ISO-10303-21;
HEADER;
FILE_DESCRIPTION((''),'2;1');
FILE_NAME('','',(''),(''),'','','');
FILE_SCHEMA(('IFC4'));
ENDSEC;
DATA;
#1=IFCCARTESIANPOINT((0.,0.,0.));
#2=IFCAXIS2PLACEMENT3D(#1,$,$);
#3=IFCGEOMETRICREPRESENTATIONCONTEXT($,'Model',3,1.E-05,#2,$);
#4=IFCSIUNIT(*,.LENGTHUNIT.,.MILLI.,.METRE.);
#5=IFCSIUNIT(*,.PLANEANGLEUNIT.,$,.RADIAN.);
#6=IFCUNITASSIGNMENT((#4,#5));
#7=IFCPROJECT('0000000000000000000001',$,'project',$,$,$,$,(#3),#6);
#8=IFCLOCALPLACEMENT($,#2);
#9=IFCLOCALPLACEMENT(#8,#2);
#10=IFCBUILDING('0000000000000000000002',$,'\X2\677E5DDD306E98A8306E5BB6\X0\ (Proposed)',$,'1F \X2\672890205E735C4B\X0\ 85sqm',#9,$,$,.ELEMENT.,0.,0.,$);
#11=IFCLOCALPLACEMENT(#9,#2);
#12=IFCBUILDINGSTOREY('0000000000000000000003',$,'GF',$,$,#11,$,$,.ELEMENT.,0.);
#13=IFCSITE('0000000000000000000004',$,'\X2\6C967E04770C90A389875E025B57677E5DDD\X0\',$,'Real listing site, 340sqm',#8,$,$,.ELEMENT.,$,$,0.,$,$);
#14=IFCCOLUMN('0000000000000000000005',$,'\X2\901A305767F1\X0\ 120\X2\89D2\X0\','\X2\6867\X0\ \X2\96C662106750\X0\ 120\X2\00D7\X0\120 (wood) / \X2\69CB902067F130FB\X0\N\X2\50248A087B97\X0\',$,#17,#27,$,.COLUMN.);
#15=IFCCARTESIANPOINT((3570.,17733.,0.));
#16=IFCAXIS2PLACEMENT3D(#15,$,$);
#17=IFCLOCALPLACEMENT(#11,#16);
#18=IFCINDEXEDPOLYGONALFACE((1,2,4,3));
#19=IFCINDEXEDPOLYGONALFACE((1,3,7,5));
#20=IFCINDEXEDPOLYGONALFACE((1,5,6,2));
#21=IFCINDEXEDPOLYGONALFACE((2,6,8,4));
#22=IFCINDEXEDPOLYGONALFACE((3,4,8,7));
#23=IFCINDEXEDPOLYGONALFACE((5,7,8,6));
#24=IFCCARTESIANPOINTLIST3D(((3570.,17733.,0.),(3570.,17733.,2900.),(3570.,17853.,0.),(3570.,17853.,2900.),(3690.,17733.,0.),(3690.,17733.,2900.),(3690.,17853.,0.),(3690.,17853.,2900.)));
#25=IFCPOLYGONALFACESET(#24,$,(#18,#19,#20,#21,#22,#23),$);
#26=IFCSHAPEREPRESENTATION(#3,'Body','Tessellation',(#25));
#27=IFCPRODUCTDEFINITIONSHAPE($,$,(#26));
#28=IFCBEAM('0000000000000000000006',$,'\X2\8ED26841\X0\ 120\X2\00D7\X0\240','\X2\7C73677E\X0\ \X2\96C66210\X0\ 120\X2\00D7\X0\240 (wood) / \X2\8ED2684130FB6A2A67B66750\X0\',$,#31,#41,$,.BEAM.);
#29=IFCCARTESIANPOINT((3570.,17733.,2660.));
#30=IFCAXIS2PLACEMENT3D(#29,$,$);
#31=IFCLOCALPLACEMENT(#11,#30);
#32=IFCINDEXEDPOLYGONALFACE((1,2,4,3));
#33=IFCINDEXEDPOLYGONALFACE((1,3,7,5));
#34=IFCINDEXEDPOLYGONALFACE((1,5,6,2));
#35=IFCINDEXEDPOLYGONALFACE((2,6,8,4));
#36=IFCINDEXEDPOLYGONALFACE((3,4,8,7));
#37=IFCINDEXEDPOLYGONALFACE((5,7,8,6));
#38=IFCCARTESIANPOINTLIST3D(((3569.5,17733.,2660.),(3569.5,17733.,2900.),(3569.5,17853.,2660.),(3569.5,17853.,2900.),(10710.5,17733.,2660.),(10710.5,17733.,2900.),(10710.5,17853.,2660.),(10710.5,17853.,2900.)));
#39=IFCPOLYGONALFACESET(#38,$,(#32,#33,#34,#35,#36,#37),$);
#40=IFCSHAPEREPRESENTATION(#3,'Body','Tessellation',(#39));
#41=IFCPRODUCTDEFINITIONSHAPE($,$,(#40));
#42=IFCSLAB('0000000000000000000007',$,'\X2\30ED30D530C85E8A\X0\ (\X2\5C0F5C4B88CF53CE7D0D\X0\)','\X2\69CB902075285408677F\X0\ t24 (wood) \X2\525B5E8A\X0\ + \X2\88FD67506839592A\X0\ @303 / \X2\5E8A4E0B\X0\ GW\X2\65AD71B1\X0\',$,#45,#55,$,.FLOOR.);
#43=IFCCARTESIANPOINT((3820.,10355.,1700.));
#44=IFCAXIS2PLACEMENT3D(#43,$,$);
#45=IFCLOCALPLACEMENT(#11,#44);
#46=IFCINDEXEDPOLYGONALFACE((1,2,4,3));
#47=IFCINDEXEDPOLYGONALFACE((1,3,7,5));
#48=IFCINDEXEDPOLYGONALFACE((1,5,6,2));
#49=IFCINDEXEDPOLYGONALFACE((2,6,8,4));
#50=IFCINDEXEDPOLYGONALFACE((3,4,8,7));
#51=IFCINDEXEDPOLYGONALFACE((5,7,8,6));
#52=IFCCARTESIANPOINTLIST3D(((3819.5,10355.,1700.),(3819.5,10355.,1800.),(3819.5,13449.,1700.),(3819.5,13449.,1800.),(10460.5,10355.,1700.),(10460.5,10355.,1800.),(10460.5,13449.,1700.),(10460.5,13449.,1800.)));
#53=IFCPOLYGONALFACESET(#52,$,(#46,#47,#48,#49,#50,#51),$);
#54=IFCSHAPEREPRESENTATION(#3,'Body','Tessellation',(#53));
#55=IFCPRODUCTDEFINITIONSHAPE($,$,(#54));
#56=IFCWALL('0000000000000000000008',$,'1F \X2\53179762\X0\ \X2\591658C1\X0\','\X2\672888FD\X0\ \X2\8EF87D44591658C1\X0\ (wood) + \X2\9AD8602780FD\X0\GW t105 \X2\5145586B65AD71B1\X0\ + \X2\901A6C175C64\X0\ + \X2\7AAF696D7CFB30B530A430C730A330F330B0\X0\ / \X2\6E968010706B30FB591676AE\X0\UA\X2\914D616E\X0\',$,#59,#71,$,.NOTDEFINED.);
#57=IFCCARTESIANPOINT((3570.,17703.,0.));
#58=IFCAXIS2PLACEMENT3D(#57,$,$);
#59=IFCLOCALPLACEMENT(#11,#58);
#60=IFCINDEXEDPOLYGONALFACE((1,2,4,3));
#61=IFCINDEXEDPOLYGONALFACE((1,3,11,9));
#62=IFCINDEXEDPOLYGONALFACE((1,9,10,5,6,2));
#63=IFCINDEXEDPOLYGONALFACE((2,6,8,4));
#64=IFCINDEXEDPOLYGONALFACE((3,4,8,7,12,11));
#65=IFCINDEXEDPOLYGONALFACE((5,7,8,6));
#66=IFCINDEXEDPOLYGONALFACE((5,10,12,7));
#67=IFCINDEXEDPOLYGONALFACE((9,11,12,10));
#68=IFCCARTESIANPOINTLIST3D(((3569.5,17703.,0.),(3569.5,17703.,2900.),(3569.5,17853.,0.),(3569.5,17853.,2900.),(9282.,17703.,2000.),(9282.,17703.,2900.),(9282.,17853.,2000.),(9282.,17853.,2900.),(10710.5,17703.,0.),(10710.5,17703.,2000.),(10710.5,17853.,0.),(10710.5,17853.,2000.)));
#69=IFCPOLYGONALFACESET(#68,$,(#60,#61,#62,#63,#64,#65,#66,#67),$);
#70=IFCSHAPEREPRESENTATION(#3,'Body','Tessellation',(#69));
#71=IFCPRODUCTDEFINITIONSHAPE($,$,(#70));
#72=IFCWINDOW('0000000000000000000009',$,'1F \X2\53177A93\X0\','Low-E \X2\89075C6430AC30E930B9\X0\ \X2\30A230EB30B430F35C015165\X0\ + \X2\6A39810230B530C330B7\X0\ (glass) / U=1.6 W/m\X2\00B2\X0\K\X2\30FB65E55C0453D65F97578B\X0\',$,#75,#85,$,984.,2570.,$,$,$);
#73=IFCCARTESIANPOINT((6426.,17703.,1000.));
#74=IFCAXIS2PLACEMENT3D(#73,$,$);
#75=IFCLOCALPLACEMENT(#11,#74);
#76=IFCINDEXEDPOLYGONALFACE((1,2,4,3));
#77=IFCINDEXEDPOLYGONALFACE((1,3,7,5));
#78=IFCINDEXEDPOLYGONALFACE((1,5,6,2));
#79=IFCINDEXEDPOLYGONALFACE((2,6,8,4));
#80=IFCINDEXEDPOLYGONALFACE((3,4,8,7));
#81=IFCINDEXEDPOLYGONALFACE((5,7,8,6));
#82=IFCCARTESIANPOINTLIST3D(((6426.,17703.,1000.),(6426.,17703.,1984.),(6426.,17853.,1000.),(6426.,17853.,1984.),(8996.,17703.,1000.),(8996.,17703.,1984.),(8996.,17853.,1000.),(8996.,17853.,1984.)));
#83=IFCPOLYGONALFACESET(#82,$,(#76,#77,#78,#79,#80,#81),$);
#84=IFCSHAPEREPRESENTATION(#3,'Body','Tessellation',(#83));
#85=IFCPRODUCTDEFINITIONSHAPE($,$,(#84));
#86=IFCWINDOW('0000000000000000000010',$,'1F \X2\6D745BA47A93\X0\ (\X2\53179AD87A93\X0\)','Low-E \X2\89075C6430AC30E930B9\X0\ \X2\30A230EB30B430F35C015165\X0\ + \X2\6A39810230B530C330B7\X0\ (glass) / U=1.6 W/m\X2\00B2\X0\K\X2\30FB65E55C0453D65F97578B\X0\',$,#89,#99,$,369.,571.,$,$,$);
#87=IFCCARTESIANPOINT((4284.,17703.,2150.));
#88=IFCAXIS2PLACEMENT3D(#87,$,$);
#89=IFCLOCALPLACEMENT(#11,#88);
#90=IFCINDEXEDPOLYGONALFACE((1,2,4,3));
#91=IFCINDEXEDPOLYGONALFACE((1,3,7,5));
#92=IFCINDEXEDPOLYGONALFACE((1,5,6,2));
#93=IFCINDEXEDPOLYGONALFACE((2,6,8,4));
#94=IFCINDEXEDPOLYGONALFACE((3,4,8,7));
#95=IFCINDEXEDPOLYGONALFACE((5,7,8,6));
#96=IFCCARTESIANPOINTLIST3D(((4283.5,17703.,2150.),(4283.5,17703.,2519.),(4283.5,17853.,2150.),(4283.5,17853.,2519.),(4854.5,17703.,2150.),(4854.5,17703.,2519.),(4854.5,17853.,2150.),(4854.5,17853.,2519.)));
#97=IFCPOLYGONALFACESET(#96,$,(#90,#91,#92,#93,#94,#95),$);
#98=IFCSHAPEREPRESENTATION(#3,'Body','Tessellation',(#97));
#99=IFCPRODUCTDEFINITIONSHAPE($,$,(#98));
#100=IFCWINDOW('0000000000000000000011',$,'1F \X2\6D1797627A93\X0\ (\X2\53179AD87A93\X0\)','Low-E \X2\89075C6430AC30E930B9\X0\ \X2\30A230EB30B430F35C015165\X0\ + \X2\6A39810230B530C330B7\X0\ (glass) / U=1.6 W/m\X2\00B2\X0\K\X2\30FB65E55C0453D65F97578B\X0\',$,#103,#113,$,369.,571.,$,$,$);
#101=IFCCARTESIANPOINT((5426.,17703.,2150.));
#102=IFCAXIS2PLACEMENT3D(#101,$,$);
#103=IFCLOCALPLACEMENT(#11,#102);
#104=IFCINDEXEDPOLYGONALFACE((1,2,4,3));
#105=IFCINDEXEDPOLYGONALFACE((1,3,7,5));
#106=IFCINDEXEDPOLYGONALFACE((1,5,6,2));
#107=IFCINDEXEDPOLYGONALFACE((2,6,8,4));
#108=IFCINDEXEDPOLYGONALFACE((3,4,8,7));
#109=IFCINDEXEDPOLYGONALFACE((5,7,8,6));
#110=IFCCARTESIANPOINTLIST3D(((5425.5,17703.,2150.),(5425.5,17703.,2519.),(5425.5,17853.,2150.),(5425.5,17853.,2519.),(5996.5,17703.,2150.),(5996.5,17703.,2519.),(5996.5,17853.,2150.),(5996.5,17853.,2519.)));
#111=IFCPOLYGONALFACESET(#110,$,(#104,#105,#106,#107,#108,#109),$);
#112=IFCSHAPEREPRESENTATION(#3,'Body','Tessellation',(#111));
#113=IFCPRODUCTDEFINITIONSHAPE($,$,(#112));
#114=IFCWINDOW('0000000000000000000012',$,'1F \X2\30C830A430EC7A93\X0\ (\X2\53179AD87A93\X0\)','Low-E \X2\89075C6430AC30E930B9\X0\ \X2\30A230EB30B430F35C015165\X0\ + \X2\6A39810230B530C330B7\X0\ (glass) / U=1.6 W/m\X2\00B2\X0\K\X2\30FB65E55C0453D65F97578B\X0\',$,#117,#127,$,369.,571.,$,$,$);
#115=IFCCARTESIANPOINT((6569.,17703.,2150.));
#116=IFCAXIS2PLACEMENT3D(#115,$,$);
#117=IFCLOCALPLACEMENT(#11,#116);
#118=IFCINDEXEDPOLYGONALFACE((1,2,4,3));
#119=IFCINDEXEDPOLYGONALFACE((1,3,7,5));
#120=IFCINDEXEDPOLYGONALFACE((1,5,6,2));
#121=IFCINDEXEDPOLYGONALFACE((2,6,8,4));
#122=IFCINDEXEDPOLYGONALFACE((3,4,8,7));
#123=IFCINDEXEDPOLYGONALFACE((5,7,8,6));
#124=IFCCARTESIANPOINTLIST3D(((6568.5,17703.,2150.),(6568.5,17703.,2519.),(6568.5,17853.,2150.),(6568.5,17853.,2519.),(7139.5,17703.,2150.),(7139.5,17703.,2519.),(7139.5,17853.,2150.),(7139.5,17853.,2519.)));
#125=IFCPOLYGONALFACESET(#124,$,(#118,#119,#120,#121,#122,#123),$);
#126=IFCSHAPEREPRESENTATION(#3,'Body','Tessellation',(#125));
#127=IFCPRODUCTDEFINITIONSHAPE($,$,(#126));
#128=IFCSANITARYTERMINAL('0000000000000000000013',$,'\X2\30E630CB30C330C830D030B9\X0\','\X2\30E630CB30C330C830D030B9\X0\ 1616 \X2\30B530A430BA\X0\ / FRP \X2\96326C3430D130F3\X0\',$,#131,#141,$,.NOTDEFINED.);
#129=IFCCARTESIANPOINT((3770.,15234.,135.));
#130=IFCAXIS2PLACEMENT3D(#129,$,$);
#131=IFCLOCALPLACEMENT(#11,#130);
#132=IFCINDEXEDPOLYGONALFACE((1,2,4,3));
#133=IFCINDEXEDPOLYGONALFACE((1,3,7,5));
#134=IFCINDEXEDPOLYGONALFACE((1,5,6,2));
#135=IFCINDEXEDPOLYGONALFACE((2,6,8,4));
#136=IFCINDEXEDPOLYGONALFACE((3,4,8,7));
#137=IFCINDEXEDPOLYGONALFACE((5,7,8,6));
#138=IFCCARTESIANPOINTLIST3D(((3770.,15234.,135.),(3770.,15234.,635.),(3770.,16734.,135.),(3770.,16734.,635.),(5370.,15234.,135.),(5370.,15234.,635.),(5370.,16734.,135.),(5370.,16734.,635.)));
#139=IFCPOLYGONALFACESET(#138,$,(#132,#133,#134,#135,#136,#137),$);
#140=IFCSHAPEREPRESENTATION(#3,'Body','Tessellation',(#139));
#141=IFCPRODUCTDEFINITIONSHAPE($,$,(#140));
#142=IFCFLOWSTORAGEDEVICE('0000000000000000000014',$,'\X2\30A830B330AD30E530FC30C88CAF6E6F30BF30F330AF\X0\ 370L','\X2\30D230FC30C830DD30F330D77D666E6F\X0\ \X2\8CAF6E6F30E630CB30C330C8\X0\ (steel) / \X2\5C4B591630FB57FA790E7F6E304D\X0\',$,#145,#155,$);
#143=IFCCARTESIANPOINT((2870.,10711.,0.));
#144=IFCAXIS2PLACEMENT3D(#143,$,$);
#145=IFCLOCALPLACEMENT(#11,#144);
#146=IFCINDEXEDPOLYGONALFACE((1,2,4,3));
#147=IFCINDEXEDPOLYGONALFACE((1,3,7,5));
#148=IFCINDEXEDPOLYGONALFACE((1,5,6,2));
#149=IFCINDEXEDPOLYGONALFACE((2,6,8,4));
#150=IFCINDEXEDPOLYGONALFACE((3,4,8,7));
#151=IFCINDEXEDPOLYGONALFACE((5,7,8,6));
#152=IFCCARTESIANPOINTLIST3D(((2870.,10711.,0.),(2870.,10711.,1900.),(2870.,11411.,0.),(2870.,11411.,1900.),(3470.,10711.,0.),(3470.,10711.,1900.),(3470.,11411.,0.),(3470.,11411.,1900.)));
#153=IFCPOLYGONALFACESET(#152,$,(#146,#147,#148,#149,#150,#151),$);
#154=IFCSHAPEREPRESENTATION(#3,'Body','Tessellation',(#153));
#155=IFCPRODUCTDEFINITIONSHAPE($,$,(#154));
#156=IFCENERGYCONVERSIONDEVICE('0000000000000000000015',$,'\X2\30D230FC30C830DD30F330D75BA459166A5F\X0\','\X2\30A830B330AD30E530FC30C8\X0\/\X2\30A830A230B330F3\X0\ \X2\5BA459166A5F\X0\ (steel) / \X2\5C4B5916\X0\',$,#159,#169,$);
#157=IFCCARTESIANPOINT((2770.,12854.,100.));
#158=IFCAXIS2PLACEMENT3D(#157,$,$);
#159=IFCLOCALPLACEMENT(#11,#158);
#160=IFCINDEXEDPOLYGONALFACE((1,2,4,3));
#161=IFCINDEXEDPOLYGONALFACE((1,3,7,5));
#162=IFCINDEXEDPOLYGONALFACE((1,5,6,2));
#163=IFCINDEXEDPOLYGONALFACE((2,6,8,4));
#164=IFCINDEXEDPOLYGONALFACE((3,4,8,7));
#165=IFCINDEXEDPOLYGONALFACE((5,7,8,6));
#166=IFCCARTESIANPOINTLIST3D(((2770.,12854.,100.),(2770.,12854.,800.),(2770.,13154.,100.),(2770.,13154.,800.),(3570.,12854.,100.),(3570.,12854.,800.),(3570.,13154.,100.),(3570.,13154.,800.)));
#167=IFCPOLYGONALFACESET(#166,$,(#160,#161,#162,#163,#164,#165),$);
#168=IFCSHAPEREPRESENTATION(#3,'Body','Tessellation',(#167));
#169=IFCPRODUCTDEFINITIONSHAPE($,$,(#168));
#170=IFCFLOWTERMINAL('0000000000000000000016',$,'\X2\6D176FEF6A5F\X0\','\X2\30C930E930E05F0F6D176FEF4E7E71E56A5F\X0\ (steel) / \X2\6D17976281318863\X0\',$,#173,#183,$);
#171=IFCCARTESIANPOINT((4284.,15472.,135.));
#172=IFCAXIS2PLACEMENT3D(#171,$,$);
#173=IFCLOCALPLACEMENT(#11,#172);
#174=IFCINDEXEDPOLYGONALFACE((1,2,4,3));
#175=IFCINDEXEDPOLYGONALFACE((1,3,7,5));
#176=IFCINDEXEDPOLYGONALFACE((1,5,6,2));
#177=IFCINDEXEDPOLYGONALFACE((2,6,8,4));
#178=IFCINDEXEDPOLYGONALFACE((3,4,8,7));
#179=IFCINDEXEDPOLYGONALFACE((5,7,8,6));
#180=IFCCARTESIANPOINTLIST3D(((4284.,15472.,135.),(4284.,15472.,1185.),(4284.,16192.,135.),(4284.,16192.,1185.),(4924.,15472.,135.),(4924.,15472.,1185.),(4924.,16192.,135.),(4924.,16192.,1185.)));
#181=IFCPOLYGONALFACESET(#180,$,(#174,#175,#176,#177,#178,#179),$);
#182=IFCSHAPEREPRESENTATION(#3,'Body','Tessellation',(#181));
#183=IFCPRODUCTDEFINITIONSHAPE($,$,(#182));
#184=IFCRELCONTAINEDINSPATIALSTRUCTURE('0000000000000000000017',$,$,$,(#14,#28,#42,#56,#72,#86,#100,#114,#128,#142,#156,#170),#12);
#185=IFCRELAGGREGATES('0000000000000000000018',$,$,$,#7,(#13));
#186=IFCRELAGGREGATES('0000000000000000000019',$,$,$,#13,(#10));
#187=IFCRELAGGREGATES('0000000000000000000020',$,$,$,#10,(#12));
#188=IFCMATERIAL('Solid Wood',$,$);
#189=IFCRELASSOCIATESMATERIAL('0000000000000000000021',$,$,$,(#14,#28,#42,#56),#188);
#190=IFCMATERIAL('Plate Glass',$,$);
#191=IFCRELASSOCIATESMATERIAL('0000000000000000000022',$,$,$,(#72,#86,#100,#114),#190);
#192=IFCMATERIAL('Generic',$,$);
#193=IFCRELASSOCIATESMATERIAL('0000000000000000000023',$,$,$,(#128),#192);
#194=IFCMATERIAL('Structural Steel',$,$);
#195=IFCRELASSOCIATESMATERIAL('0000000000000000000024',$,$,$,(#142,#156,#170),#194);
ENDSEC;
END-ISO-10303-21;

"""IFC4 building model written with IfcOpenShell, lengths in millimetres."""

from ifc_helpers import new_model, si_unit, frame, frame_2d, origin, place, context, project, spatial, rectangle, extrude, material, element, fill, save


model = new_model("IFC4")

# Units and contexts
model_context = context("Model", 3, precision=1e-05, world=origin())
ifc_project = project(units=[si_unit("LENGTHUNIT", "METRE", prefix="MILLI"), si_unit("PLANEANGLEUNIT", "RADIAN")], contexts=[model_context])

# Site, building, storey
site_placement = place(None, origin())
site = spatial("IfcSite", under=ifc_project, at=site_placement, Name="沖縄県那覇市字松川", ObjectType="Real listing site, 340sqm", CompositionType="ELEMENT", RefElevation=0.0)
building_placement = place(site_placement, origin())
building = spatial("IfcBuilding", under=site, at=building_placement, Name="松川の風の家 (Proposed)", ObjectType="1F 木造平屋 85sqm", CompositionType="ELEMENT", ElevationOfRefHeight=0.0, ElevationOfTerrain=0.0)
storey_placement = place(building_placement, origin())
storey = spatial("IfcBuildingStorey", under=building, at=storey_placement, Name="GF", CompositionType="ELEMENT", Elevation=0.0)

# Column
ifc_material_1 = material(Name="Solid Wood")
column_1_placement = place(storey_placement, frame((3570.0, 17733.0, 0.0)))
element("IfcColumn", 1, at=column_1_placement, inside=storey, material=ifc_material_1, Name="通し柱 120角", Description="桧 集成材 120×120 (wood) / 構造柱・N値計算", PredefinedType="COLUMN", context=model_context, shape_type="SweptSolid", body=[
    extrude(rectangle(XDim=120.0, YDim=120.0, at=frame_2d((60.0, 60.0))), frame((3570.0, 17733.0, 0.0)), (0.0, 0.0, 1.0), 2900.0),
])

# Beam
beam_1_placement = place(storey_placement, frame((3570.0, 17733.0, 2660.0)))
element("IfcBeam", 2, at=beam_1_placement, inside=storey, material=ifc_material_1, Name="軒桁 120×240", Description="米松 集成 120×240 (wood) / 軒桁・横架材", PredefinedType="BEAM", context=model_context, shape_type="SweptSolid", body=[
    extrude(rectangle(XDim=7141.0, YDim=120.0, at=frame_2d((3570.0, 60.0))), frame((3570.0, 17733.0, 2660.0)), (0.0, 0.0, 1.0), 240.0),
])

# Slab
slab_placement = place(storey_placement, frame((3820.0, 10355.0, 1700.0)))
element("IfcSlab", 3, at=slab_placement, inside=storey, material=ifc_material_1, Name="ロフト床 (小屋裏収納)", Description="構造用合板 t24 (wood) 剛床 + 製材根太 @303 / 床下 GW断熱", PredefinedType="FLOOR", context=model_context, shape_type="SweptSolid", body=[
    extrude(rectangle(XDim=6641.0, YDim=3094.0, at=frame_2d((3320.0, 1547.0))), frame((3820.0, 10355.0, 1700.0)), (0.0, 0.0, 1.0), 100.0),
])

# Wall, openings, windows
wall_1_placement = place(storey_placement, frame((3570.0, 17703.0, 0.0)))
wall_1 = element("IfcWall", 4, at=wall_1_placement, inside=storey, material=ifc_material_1, Name="1F 北面 外壁", Description="木製 軸組外壁 (wood) + 高性能GW t105 充填断熱 + 通気層 + 窯業系サイディング / 準耐火・外皮UA配慮", PredefinedType="NOTDEFINED", context=model_context, shape_type="SweptSolid", body=[
    extrude(rectangle(XDim=7141.0, YDim=150.0, at=frame_2d((3570.0, 75.0))), frame((3570.0, 17703.0, 0.0)), (0.0, 0.0, 1.0), 2900.0),
])
opening_1_placement = place(storey_placement, frame((6426.0, 17703.0, 1000.0)))
opening_1 = element("IfcOpeningElement", 5, at=opening_1_placement, cuts=wall_1, PredefinedType="NOTDEFINED", context=model_context, shape_type="SweptSolid", body=[
    extrude(rectangle(XDim=2570.0, YDim=150.0, at=frame_2d((1285.0, 75.0))), frame((6426.0, 17703.0, 1000.0)), (0.0, 0.0, 1.0), 984.0),
])
opening_2_placement = place(storey_placement, frame((4284.0, 17703.0, 2150.0)))
opening_2 = element("IfcOpeningElement", 6, at=opening_2_placement, cuts=wall_1, PredefinedType="NOTDEFINED", context=model_context, shape_type="SweptSolid", body=[
    extrude(rectangle(XDim=571.0, YDim=150.0, at=frame_2d((285.0, 75.0))), frame((4284.0, 17703.0, 2150.0)), (0.0, 0.0, 1.0), 369.0),
])
opening_3_placement = place(storey_placement, frame((5426.0, 17703.0, 2150.0)))
opening_3 = element("IfcOpeningElement", 7, at=opening_3_placement, cuts=wall_1, PredefinedType="NOTDEFINED", context=model_context, shape_type="SweptSolid", body=[
    extrude(rectangle(XDim=571.0, YDim=150.0, at=frame_2d((285.0, 75.0))), frame((5426.0, 17703.0, 2150.0)), (0.0, 0.0, 1.0), 369.0),
])
opening_4_placement = place(storey_placement, frame((6569.0, 17703.0, 2150.0)))
opening_4 = element("IfcOpeningElement", 8, at=opening_4_placement, cuts=wall_1, PredefinedType="NOTDEFINED", context=model_context, shape_type="SweptSolid", body=[
    extrude(rectangle(XDim=571.0, YDim=150.0, at=frame_2d((285.0, 75.0))), frame((6569.0, 17703.0, 2150.0)), (0.0, 0.0, 1.0), 369.0),
])
ifc_material_2 = material(Name="Plate Glass")
window_1_placement = place(storey_placement, frame((6426.0, 17703.0, 1000.0)))
window_1 = element("IfcWindow", 9, at=window_1_placement, inside=storey, material=ifc_material_2, Name="1F 北窓", Description="Low-E 複層ガラス アルゴン封入 + 樹脂サッシ (glass) / U=1.6 W/m²K・日射取得型", OverallHeight=984.0, OverallWidth=2570.0, context=model_context, shape_type="SweptSolid", body=[
    extrude(rectangle(XDim=2570.0, YDim=150.0, at=frame_2d((1285.0, 75.0))), frame((6426.0, 17703.0, 1000.0)), (0.0, 0.0, 1.0), 984.0),
])
fill(opening_1, window_1)
window_2_placement = place(storey_placement, frame((4284.0, 17703.0, 2150.0)))
window_2 = element("IfcWindow", 10, at=window_2_placement, inside=storey, material=ifc_material_2, Name="1F 浴室窓 (北高窓)", Description="Low-E 複層ガラス アルゴン封入 + 樹脂サッシ (glass) / U=1.6 W/m²K・日射取得型", OverallHeight=369.0, OverallWidth=571.0, context=model_context, shape_type="SweptSolid", body=[
    extrude(rectangle(XDim=571.0, YDim=150.0, at=frame_2d((285.0, 75.0))), frame((4284.0, 17703.0, 2150.0)), (0.0, 0.0, 1.0), 369.0),
])
fill(opening_2, window_2)
window_3_placement = place(storey_placement, frame((5426.0, 17703.0, 2150.0)))
window_3 = element("IfcWindow", 11, at=window_3_placement, inside=storey, material=ifc_material_2, Name="1F 洗面窓 (北高窓)", Description="Low-E 複層ガラス アルゴン封入 + 樹脂サッシ (glass) / U=1.6 W/m²K・日射取得型", OverallHeight=369.0, OverallWidth=571.0, context=model_context, shape_type="SweptSolid", body=[
    extrude(rectangle(XDim=571.0, YDim=150.0, at=frame_2d((285.0, 75.0))), frame((5426.0, 17703.0, 2150.0)), (0.0, 0.0, 1.0), 369.0),
])
fill(opening_3, window_3)
window_4_placement = place(storey_placement, frame((6569.0, 17703.0, 2150.0)))
window_4 = element("IfcWindow", 12, at=window_4_placement, inside=storey, material=ifc_material_2, Name="1F トイレ窓 (北高窓)", Description="Low-E 複層ガラス アルゴン封入 + 樹脂サッシ (glass) / U=1.6 W/m²K・日射取得型", OverallHeight=369.0, OverallWidth=571.0, context=model_context, shape_type="SweptSolid", body=[
    extrude(rectangle(XDim=571.0, YDim=150.0, at=frame_2d((285.0, 75.0))), frame((6569.0, 17703.0, 2150.0)), (0.0, 0.0, 1.0), 369.0),
])
fill(opening_4, window_4)

# Sanitary terminal
ifc_material_3 = material(Name="Generic")
sanitary_terminal_placement = place(storey_placement, frame((3770.0, 15234.0, 135.0)))
element("IfcSanitaryTerminal", 13, at=sanitary_terminal_placement, inside=storey, material=ifc_material_3, Name="ユニットバス", Description="ユニットバス 1616 サイズ / FRP 防水パン", PredefinedType="NOTDEFINED", context=model_context, shape_type="SweptSolid", body=[
    extrude(rectangle(XDim=1600.0, YDim=1500.0, at=frame_2d((800.0, 750.0))), frame((3770.0, 15234.0, 135.0)), (0.0, 0.0, 1.0), 500.0),
])

# Flow storage device
ifc_material_4 = material(Name="Structural Steel")
flow_storage_device_placement = place(storey_placement, frame((2870.0, 10711.0, 0.0)))
element("IfcFlowStorageDevice", 14, at=flow_storage_device_placement, inside=storey, material=ifc_material_4, Name="エコキュート貯湯タンク 370L", Description="ヒートポンプ給湯 貯湯ユニット (steel) / 屋外・基礎置き", context=model_context, shape_type="SweptSolid", body=[
    extrude(rectangle(XDim=600.0, YDim=700.0, at=frame_2d((300.0, 350.0))), frame((2870.0, 10711.0, 0.0)), (0.0, 0.0, 1.0), 1900.0),
])

# Energy conversion device
energy_conversion_device_placement = place(storey_placement, frame((2770.0, 12854.0, 100.0)))
element("IfcEnergyConversionDevice", 15, at=energy_conversion_device_placement, inside=storey, material=ifc_material_4, Name="ヒートポンプ室外機", Description="エコキュート/エアコン 室外機 (steel) / 屋外", context=model_context, shape_type="SweptSolid", body=[
    extrude(rectangle(XDim=800.0, YDim=300.0, at=frame_2d((400.0, 150.0))), frame((2770.0, 12854.0, 100.0)), (0.0, 0.0, 1.0), 700.0),
])

# Flow terminal
flow_terminal_placement = place(storey_placement, frame((4284.0, 15472.0, 135.0)))
element("IfcFlowTerminal", 16, at=flow_terminal_placement, inside=storey, material=ifc_material_4, Name="洗濯機", Description="ドラム式洗濯乾燥機 (steel) / 洗面脱衣", context=model_context, shape_type="SweptSolid", body=[
    extrude(rectangle(XDim=640.0, YDim=720.0, at=frame_2d((320.0, 360.0))), frame((4284.0, 15472.0, 135.0)), (0.0, 0.0, 1.0), 1050.0),
])

save(model, "model.ifc")
